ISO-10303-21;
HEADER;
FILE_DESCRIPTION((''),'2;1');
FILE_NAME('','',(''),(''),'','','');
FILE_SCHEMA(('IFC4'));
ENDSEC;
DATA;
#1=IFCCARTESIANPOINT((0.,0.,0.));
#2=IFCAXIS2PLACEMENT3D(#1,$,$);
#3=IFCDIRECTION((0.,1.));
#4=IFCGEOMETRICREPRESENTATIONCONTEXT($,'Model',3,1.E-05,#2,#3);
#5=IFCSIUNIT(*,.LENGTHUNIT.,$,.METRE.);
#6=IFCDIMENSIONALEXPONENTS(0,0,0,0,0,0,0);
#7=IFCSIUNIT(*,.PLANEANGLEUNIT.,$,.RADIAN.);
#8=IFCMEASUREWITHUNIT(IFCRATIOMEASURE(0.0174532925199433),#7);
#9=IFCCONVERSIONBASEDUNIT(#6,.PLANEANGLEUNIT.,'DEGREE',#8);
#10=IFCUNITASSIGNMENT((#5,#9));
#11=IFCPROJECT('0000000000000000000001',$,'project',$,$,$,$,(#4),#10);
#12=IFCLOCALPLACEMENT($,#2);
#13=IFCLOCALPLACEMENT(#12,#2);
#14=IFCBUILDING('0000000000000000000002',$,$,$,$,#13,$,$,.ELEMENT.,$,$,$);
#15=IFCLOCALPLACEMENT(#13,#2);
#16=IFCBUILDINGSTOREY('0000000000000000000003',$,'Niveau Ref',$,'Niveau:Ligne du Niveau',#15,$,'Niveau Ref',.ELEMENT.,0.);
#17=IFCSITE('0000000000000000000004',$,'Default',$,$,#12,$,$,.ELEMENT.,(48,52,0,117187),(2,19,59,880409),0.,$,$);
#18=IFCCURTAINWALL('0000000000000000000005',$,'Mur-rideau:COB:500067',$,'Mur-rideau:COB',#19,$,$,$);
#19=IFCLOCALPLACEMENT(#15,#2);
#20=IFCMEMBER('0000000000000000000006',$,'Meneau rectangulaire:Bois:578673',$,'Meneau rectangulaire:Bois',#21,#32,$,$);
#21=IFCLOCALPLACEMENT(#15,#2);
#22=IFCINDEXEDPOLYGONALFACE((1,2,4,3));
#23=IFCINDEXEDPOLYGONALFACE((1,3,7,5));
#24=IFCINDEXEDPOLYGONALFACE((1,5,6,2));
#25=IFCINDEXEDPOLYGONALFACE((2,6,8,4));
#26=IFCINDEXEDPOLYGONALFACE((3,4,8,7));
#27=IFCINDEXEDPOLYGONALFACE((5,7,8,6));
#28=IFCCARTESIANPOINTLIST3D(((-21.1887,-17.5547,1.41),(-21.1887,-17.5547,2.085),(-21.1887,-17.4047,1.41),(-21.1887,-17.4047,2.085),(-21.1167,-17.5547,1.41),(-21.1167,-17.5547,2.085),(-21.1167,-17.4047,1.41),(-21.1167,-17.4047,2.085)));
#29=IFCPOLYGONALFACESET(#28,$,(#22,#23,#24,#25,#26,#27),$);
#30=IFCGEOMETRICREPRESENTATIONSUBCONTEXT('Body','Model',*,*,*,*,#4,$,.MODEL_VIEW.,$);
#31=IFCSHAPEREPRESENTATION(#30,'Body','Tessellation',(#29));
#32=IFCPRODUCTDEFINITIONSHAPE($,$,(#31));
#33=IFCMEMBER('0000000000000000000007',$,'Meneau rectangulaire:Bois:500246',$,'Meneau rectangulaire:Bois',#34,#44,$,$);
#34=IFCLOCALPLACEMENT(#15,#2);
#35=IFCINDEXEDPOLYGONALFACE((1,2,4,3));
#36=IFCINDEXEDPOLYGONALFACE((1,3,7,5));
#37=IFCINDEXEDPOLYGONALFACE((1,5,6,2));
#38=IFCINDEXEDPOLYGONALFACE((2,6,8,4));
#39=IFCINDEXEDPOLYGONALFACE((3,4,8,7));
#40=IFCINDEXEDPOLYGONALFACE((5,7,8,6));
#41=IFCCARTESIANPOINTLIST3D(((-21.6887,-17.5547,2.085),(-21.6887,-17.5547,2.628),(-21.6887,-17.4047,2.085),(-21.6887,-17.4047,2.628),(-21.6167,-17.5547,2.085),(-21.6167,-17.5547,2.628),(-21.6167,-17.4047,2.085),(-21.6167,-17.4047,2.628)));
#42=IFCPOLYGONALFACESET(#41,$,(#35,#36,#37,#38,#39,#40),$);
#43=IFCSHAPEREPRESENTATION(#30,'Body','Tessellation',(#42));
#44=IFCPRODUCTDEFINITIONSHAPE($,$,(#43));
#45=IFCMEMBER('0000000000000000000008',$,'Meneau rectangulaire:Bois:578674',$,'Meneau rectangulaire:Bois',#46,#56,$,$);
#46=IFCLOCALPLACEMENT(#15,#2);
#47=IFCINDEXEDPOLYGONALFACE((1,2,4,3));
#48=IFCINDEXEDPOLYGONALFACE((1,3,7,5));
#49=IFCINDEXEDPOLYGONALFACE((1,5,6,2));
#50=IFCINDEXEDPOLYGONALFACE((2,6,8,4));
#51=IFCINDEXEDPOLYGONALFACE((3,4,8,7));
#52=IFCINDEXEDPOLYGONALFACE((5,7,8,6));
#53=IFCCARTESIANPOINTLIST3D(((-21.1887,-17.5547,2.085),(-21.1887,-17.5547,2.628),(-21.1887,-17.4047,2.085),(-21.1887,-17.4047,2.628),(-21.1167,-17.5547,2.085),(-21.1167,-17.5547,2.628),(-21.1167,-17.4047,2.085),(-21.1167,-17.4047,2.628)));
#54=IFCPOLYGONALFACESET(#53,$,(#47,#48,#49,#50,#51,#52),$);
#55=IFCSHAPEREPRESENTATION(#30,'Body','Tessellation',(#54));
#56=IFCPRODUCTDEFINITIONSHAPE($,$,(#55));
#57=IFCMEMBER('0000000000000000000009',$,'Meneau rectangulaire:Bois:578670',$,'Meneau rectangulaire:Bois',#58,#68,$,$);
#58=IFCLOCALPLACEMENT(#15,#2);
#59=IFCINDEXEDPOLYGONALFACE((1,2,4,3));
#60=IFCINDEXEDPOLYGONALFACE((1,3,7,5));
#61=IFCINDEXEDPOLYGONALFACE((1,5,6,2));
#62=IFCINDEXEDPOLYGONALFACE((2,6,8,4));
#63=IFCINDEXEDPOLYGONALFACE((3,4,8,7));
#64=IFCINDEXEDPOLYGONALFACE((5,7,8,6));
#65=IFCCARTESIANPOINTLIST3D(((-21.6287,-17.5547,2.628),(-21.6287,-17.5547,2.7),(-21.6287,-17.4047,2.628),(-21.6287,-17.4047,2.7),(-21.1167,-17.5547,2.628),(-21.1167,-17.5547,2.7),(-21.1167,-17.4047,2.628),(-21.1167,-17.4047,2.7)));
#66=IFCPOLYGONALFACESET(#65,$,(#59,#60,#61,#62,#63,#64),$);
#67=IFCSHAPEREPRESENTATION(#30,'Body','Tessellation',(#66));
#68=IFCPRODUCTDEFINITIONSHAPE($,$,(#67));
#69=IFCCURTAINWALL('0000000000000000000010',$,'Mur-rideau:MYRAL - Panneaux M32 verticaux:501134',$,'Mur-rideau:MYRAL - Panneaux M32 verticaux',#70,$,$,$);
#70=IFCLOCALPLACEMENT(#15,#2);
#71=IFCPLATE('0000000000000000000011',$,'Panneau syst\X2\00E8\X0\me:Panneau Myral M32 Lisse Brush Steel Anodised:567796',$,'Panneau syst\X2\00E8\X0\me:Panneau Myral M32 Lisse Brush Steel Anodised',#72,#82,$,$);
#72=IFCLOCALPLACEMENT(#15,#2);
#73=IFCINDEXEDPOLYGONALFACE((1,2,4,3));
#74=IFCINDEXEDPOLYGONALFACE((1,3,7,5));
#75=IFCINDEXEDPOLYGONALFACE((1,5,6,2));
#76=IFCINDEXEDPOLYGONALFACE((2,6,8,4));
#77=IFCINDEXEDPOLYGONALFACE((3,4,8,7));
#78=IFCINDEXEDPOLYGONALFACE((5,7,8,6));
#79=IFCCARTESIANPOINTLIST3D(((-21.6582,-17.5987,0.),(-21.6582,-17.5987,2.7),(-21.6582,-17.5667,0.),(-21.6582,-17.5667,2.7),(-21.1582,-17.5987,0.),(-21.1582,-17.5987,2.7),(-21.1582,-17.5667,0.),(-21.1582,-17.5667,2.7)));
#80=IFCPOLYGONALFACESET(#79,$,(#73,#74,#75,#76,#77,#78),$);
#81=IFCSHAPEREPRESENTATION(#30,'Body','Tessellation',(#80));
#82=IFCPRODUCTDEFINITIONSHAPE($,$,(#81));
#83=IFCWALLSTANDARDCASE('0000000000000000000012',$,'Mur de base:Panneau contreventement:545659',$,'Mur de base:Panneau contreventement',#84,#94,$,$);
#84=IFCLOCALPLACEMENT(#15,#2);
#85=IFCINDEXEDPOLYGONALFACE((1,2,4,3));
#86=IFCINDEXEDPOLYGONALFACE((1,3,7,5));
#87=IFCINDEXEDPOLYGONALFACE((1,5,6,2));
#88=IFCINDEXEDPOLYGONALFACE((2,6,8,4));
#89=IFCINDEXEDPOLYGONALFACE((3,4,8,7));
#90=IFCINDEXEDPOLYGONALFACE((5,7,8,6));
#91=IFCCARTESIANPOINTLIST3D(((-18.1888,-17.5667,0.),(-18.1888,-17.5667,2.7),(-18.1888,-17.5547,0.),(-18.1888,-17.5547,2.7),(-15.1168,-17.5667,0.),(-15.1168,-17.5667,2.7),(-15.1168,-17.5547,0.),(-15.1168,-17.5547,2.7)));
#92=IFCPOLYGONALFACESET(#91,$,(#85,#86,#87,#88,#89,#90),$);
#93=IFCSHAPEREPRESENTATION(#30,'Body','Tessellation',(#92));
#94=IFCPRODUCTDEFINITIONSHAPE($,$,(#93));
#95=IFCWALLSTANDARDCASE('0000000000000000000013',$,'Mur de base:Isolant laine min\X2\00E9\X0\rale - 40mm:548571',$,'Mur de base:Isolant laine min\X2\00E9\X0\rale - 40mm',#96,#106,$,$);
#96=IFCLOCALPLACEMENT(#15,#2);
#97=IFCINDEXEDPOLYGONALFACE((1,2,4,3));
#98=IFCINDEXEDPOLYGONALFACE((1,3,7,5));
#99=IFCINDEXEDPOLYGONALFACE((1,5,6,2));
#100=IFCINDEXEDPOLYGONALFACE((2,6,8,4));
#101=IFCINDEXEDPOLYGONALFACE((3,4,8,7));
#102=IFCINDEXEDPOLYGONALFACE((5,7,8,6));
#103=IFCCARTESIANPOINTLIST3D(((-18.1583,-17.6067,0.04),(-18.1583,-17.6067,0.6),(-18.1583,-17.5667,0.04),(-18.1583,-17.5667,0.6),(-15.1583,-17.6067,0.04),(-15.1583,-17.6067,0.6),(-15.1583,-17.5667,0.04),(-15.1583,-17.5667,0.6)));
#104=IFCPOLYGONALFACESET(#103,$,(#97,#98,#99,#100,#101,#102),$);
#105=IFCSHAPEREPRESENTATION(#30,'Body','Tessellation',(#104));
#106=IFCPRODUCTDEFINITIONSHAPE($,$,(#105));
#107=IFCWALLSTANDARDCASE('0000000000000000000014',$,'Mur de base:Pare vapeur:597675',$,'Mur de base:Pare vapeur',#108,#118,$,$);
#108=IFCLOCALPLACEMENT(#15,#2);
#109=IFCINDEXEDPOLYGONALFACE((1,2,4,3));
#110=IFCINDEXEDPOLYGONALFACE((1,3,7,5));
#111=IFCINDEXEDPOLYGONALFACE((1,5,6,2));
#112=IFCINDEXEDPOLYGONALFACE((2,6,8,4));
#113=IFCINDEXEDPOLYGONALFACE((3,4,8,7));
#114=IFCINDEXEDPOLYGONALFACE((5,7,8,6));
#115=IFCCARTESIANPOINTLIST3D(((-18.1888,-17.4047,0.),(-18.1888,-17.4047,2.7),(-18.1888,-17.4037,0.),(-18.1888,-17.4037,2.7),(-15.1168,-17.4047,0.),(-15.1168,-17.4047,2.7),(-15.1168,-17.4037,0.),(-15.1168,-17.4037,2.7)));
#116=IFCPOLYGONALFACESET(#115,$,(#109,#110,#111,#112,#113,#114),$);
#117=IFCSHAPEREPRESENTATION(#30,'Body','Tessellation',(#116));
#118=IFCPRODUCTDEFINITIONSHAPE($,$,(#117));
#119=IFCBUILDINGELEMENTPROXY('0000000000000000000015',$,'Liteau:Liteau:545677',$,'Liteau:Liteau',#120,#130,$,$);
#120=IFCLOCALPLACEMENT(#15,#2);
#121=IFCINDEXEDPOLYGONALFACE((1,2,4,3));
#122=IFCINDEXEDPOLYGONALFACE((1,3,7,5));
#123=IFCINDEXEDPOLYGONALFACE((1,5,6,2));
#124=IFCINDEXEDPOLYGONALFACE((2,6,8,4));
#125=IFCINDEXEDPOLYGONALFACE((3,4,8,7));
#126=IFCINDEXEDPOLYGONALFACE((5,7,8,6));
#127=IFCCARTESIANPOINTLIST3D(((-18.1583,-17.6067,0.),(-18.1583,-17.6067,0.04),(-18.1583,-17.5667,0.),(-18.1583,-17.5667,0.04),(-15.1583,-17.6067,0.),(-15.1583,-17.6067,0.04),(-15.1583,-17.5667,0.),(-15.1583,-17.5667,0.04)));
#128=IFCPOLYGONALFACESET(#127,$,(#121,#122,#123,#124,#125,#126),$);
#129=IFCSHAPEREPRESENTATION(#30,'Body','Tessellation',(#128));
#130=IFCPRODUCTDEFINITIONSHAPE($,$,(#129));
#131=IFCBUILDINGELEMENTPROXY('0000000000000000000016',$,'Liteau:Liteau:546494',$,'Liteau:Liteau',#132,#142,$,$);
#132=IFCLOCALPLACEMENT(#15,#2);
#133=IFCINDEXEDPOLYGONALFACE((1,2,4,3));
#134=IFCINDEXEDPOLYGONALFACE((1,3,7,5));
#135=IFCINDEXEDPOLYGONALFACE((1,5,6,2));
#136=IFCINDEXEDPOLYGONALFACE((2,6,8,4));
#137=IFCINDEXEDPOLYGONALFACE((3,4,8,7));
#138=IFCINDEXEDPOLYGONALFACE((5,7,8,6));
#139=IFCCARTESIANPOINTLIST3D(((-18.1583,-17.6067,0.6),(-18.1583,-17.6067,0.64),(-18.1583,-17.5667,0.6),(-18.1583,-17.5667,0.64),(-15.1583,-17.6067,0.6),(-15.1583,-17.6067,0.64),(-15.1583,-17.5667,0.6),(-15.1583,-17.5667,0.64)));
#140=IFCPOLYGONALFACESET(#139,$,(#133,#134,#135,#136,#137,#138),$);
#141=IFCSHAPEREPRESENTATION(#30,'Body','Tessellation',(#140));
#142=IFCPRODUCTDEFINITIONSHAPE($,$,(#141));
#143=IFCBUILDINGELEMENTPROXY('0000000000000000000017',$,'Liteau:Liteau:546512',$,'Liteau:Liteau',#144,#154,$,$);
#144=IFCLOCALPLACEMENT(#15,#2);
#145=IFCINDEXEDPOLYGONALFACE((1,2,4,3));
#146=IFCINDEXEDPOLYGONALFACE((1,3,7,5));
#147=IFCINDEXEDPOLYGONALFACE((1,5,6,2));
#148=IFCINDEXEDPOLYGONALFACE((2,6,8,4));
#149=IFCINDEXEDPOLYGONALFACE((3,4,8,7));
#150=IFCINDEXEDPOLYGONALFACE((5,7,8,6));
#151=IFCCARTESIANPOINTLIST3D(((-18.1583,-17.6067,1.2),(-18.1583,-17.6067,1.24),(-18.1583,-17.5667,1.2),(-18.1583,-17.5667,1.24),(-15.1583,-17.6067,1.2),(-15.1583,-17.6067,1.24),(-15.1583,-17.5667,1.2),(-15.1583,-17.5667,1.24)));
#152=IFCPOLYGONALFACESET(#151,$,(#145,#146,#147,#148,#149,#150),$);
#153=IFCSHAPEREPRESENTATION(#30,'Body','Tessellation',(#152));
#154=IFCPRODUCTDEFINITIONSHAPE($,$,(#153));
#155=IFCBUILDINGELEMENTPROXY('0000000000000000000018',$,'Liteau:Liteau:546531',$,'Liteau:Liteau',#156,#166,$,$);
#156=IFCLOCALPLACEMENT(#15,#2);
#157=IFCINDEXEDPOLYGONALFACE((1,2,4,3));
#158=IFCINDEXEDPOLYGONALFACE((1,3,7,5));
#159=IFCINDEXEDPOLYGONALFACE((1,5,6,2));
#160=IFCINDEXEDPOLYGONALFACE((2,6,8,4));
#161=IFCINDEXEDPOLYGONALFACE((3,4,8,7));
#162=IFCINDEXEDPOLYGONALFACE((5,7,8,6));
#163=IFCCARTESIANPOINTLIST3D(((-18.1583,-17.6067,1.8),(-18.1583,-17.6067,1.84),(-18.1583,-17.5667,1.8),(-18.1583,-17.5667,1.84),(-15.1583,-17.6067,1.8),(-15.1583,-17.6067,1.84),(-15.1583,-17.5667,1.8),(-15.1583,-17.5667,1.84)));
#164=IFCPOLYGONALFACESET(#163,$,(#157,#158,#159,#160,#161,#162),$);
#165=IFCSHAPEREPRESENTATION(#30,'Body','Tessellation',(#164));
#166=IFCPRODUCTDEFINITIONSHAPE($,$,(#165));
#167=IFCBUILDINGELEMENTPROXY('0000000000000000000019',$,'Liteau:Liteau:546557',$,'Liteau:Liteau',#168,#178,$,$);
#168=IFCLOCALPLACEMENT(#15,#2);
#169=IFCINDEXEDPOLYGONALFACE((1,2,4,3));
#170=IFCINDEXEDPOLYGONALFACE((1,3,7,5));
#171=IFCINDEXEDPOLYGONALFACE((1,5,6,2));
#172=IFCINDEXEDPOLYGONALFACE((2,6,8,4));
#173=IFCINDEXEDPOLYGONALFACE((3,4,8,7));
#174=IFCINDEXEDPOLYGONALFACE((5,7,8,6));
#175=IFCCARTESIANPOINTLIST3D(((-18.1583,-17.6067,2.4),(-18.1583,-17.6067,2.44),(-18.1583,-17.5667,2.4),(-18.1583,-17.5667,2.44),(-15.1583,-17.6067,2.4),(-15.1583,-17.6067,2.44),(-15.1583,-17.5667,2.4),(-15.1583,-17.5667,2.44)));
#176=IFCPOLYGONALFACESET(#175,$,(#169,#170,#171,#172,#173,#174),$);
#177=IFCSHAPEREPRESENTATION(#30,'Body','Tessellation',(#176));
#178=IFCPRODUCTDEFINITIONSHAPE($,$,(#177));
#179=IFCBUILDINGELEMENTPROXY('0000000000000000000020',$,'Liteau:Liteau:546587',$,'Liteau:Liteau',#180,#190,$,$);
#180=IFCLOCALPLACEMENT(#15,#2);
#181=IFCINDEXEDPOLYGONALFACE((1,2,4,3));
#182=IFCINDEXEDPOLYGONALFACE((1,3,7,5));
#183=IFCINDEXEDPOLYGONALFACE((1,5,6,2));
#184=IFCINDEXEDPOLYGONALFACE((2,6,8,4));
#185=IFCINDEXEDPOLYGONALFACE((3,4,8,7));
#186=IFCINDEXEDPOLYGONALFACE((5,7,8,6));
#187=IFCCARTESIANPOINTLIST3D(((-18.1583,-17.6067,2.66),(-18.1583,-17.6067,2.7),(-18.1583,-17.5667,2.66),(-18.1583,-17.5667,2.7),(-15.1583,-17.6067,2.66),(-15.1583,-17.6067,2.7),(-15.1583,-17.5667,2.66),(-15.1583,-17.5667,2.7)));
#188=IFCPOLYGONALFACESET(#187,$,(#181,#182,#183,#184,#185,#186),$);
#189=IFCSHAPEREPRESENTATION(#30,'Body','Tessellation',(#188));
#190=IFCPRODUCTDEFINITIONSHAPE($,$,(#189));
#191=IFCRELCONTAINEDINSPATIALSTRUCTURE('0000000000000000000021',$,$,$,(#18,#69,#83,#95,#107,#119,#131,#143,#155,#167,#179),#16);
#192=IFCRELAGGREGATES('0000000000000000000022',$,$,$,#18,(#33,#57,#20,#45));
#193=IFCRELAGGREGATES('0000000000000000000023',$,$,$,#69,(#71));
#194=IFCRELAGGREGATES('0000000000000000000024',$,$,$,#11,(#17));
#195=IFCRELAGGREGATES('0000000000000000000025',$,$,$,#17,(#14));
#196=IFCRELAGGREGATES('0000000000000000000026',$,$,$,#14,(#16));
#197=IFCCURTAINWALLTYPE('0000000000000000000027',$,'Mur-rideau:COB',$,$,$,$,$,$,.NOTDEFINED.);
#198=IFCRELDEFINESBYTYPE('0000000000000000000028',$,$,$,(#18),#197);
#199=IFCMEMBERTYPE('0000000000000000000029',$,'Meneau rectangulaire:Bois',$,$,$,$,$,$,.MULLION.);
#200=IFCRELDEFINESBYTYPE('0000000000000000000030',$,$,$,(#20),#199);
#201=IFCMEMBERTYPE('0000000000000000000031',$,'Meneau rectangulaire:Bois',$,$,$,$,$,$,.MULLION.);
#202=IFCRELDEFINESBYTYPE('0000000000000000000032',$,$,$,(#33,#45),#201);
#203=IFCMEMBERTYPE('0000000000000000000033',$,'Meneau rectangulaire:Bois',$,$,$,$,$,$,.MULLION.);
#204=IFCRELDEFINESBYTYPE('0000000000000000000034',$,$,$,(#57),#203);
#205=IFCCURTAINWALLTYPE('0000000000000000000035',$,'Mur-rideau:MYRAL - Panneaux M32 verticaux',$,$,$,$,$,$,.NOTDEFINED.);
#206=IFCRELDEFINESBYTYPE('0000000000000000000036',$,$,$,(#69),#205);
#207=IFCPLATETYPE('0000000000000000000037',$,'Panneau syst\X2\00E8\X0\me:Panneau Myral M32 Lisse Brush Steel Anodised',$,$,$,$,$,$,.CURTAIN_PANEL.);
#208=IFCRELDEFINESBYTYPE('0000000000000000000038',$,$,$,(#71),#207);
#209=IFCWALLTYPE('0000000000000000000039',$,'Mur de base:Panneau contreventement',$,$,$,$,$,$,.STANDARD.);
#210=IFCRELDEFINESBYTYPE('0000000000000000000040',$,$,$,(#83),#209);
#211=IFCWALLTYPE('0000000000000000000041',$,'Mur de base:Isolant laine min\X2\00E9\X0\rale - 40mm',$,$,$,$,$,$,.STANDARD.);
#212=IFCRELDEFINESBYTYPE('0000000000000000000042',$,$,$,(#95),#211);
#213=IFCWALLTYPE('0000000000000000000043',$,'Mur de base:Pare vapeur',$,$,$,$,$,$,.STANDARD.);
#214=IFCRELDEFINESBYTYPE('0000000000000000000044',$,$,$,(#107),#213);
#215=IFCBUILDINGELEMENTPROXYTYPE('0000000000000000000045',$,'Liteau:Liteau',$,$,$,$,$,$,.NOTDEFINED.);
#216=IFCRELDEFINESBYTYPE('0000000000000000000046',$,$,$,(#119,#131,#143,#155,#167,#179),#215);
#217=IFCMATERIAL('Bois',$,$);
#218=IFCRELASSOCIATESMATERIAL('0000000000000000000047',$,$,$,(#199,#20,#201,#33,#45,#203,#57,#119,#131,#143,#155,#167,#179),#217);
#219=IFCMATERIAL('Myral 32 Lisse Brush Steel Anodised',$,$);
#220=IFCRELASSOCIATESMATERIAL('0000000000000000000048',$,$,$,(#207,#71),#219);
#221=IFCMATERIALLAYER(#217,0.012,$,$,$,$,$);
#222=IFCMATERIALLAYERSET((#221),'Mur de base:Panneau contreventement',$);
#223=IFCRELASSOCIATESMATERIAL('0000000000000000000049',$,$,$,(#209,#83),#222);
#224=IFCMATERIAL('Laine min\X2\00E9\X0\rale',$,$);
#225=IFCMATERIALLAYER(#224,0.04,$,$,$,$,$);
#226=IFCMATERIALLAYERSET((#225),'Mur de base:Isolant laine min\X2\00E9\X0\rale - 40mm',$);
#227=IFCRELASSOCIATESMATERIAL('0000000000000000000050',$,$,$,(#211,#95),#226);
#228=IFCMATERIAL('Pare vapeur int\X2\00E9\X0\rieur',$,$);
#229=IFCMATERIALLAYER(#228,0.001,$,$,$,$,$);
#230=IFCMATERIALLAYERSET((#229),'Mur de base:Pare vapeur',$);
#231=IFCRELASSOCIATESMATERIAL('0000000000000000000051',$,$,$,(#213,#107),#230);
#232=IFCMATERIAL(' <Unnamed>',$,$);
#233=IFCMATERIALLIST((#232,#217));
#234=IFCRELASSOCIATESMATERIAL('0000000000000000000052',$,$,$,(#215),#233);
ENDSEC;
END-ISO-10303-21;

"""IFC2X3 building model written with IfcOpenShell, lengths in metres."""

from ifc_helpers import new_model, entity, si_unit, converted_unit, direction, frame, frame_2d, origin, origin_2d_with_axis, place, context, subcontext, project, spatial, rectangle, extrude, source, transform, mapped, material, material_list, layer, layer_set, layer_usage, type_object, type_shapes, element, aggregate, save


model = new_model("IFC2X3")

# Units and contexts
model_context = context("Model", 3, precision=1e-05, world=origin(), true_north=direction((0.0, 1.0)))
body_context = subcontext(model_context, "Body", "Model", "MODEL_VIEW")
ifc_project = project(units=[si_unit("LENGTHUNIT", "METRE"), converted_unit("PLANEANGLEUNIT", "DEGREE", entity("IfcRatioMeasure", 0.0174532925199433), si_unit("PLANEANGLEUNIT", "RADIAN"), dimensions=[0, 0, 0, 0, 0, 0, 0])], contexts=[model_context])

# Site, building, storey
site_placement = place(None, origin())
site = spatial("IfcSite", under=ifc_project, at=site_placement, Name="Default", CompositionType="ELEMENT", RefLatitude=(48, 52, 0, 117187), RefLongitude=(2, 19, 59, 880409), RefElevation=0.0)
building_placement = place(site_placement, origin())
building = spatial("IfcBuilding", under=site, at=building_placement, CompositionType="ELEMENT")
storey_placement = place(building_placement, origin())
storey = spatial("IfcBuildingStorey", under=building, at=storey_placement, Name="Niveau Ref", ObjectType="Niveau:Ligne du Niveau", LongName="Niveau Ref", CompositionType="ELEMENT", Elevation=0.0)

# Curtain wall, members
curtain_wall_type_1 = type_object("IfcCurtainWallType", Name="Mur-rideau:COB", PredefinedType="NOTDEFINED")
ifc_material_1 = material(Name="Bois")
curtain_wall_1_placement = place(storey_placement, origin())
curtain_wall_1 = element("IfcCurtainWall", 1, at=curtain_wall_1_placement, inside=storey, type_object=curtain_wall_type_1, Name="Mur-rideau:COB:500067", ObjectType="Mur-rideau:COB")
member_type_1 = type_object("IfcMemberType", Name="Meneau rectangulaire:Bois", PredefinedType="MULLION", material=ifc_material_1)
shared_shape_1 = source(origin(), body_context, "Body", "SweptSolid", [
    extrude(rectangle(XDim=0.15, YDim=0.072, at=origin_2d_with_axis()), frame((-0.024, 0.0, -0.675), z_axis=(0.0, 0.0, 1.0), x_axis=(0.0, -1.0, 0.0)), (0.0, 0.0, 1.0), 0.675),
])
type_shapes(member_type_1, [shared_shape_1])
member_1_placement = place(storey_placement, frame((-21.1287, -17.4797, 1.41), z_axis=(0.0, 0.0, -1.0), x_axis=(1.0, 0.0, 0.0)))
member_1 = element("IfcMember", 2, at=member_1_placement, type_object=member_type_1, material=ifc_material_1, Name="Meneau rectangulaire:Bois:578673", ObjectType="Meneau rectangulaire:Bois", context=body_context, shape_type="MappedRepresentation", body=[
    mapped(shared_shape_1, transform((0.0, 0.0, 0.0), scale=1.0)),
])
member_type_2 = type_object("IfcMemberType", Name="Meneau rectangulaire:Bois", PredefinedType="MULLION", material=ifc_material_1)
shared_shape_2 = source(origin(), body_context, "Body", "SweptSolid", [
    extrude(rectangle(XDim=0.15, YDim=0.072, at=origin_2d_with_axis()), frame((-0.024, 0.0, -0.543), z_axis=(0.0, 0.0, 1.0), x_axis=(0.0, -1.0, 0.0)), (0.0, 0.0, 1.0), 0.543),
])
type_shapes(member_type_2, [shared_shape_2])
member_2_placement = place(storey_placement, frame((-21.6287, -17.4797, 2.085), z_axis=(0.0, 0.0, -1.0), x_axis=(1.0, 0.0, 0.0)))
member_2 = element("IfcMember", 3, at=member_2_placement, type_object=member_type_2, material=ifc_material_1, Name="Meneau rectangulaire:Bois:500246", ObjectType="Meneau rectangulaire:Bois", context=body_context, shape_type="MappedRepresentation", body=[
    mapped(shared_shape_2, transform((0.0, 0.0, 0.0), scale=1.0)),
])
member_3_placement = place(storey_placement, frame((-21.1287, -17.4797, 2.085), z_axis=(0.0, 0.0, -1.0), x_axis=(1.0, 0.0, 0.0)))
member_3 = element("IfcMember", 4, at=member_3_placement, type_object=member_type_2, material=ifc_material_1, Name="Meneau rectangulaire:Bois:578674", ObjectType="Meneau rectangulaire:Bois", context=body_context, shape_type="MappedRepresentation", body=[
    mapped(shared_shape_2, transform((0.0, 0.0, 0.0), scale=1.0)),
])
member_type_3 = type_object("IfcMemberType", Name="Meneau rectangulaire:Bois", PredefinedType="MULLION", material=ifc_material_1)
shared_shape_3 = source(origin(), body_context, "Body", "SweptSolid", [
    extrude(rectangle(XDim=0.15, YDim=0.072, at=origin_2d_with_axis()), frame((-0.036, 0.0, -0.512), z_axis=(0.0, 0.0, 1.0), x_axis=(0.0, -1.0, 0.0)), (0.0, 0.0, 1.0), 0.512),
])
type_shapes(member_type_3, [shared_shape_3])
member_4_placement = place(storey_placement, frame((-21.1167, -17.4797, 2.7), z_axis=(1.0, 0.0, 0.0), x_axis=(0.0, 0.0, 1.0)))
member_4 = element("IfcMember", 5, at=member_4_placement, type_object=member_type_3, material=ifc_material_1, Name="Meneau rectangulaire:Bois:578670", ObjectType="Meneau rectangulaire:Bois", context=body_context, shape_type="MappedRepresentation", body=[
    mapped(shared_shape_3, transform((0.0, 0.0, 0.0), scale=1.0)),
])
aggregate(curtain_wall_1, [member_2, member_4, member_1, member_3])

# Curtain wall, plate
curtain_wall_type_2 = type_object("IfcCurtainWallType", Name="Mur-rideau:MYRAL - Panneaux M32 verticaux", PredefinedType="NOTDEFINED")
curtain_wall_2_placement = place(storey_placement, origin())
curtain_wall_2 = element("IfcCurtainWall", 6, at=curtain_wall_2_placement, inside=storey, type_object=curtain_wall_type_2, Name="Mur-rideau:MYRAL - Panneaux M32 verticaux:501134", ObjectType="Mur-rideau:MYRAL - Panneaux M32 verticaux")
ifc_material_2 = material(Name="Myral 32 Lisse Brush Steel Anodised")
plate_type = type_object("IfcPlateType", Name="Panneau système:Panneau Myral M32 Lisse Brush Steel Anodised", PredefinedType="CURTAIN_PANEL", material=ifc_material_2)
shared_shape_4 = source(origin(), body_context, "Body", "SweptSolid", [
    extrude(rectangle(XDim=0.032, YDim=0.5, at=origin_2d_with_axis()), frame((0.0, -0.016, 0.0), z_axis=(0.0, 0.0, 1.0), x_axis=(0.0, 1.0, 0.0)), (0.0, 0.0, 1.0), 2.7),
])
type_shapes(plate_type, [shared_shape_4])
plate_placement = place(curtain_wall_2_placement, frame((-21.4082, -17.5667, 0.0)))
plate = element("IfcPlate", 7, at=plate_placement, type_object=plate_type, material=ifc_material_2, Name="Panneau système:Panneau Myral M32 Lisse Brush Steel Anodised:567796", ObjectType="Panneau système:Panneau Myral M32 Lisse Brush Steel Anodised", context=body_context, shape_type="MappedRepresentation", body=[
    mapped(shared_shape_4, transform((0.0, 0.0, 0.0), scale=1.0)),
])
aggregate(curtain_wall_2, [plate])

# Walls
ifc_layer_1 = layer(ifc_material_1, 0.012)
ifc_layer_set_1 = layer_set([ifc_layer_1], Name="Mur de base:Panneau contreventement")
ifc_layer_usage_1 = layer_usage(ifc_layer_set_1, "AXIS2", "NEGATIVE", 0.006)
wall_type_1 = type_object("IfcWallType", Name="Mur de base:Panneau contreventement", PredefinedType="STANDARD", material=ifc_layer_set_1)
wall_1_placement = place(storey_placement, frame((-18.1888, -17.5607, 0.0)))
element("IfcWallStandardCase", 8, at=wall_1_placement, inside=storey, type_object=wall_type_1, material=ifc_layer_usage_1, Name="Mur de base:Panneau contreventement:545659", ObjectType="Mur de base:Panneau contreventement", context=body_context, shape_type="SweptSolid", body=[
    extrude(rectangle(XDim=3.072, YDim=0.012, at=frame_2d((1.536, 0.0), x_axis=(-1.0, 0.0))), origin(), (0.0, 0.0, 1.0), 2.7),
])
ifc_material_3 = material(Name="Laine minérale")
ifc_layer_2 = layer(ifc_material_3, 0.04)
ifc_layer_set_2 = layer_set([ifc_layer_2], Name="Mur de base:Isolant laine minérale - 40mm")
ifc_layer_usage_2 = layer_usage(ifc_layer_set_2, "AXIS2", "NEGATIVE", 0.02)
wall_type_2 = type_object("IfcWallType", Name="Mur de base:Isolant laine minérale - 40mm", PredefinedType="STANDARD", material=ifc_layer_set_2)
wall_2_placement = place(storey_placement, frame((-18.1583, -17.5867, 0.04)))
element("IfcWallStandardCase", 9, at=wall_2_placement, inside=storey, type_object=wall_type_2, material=ifc_layer_usage_2, Name="Mur de base:Isolant laine minérale - 40mm:548571", ObjectType="Mur de base:Isolant laine minérale - 40mm", context=body_context, shape_type="SweptSolid", body=[
    extrude(rectangle(XDim=3.0, YDim=0.04, at=frame_2d((1.5, 0.0), x_axis=(-1.0, 0.0))), origin(), (0.0, 0.0, 1.0), 0.56),
])
ifc_material_4 = material(Name="Pare vapeur intérieur")
ifc_layer_3 = layer(ifc_material_4, 0.001)
ifc_layer_set_3 = layer_set([ifc_layer_3], Name="Mur de base:Pare vapeur")
ifc_layer_usage_3 = layer_usage(ifc_layer_set_3, "AXIS2", "NEGATIVE", 0.0005)
wall_type_3 = type_object("IfcWallType", Name="Mur de base:Pare vapeur", PredefinedType="STANDARD", material=ifc_layer_set_3)
wall_3_placement = place(storey_placement, frame((-18.1888, -17.4042, 0.0)))
element("IfcWallStandardCase", 10, at=wall_3_placement, inside=storey, type_object=wall_type_3, material=ifc_layer_usage_3, Name="Mur de base:Pare vapeur:597675", ObjectType="Mur de base:Pare vapeur", context=body_context, shape_type="SweptSolid", body=[
    extrude(rectangle(XDim=3.072, YDim=0.001, at=frame_2d((1.536, 0.0), x_axis=(-1.0, 0.0))), origin(), (0.0, 0.0, 1.0), 2.7),
])

# Building element proxies
ifc_material_5 = material(Name=" <Unnamed>")
ifc_material_list = material_list([ifc_material_5, ifc_material_1])
building_element_proxy_type = type_object("IfcBuildingElementProxyType", Name="Liteau:Liteau", PredefinedType="NOTDEFINED", material=ifc_material_list)
shared_shape_5 = source(origin(), body_context, "Body", "SweptSolid", [
    extrude(rectangle(XDim=3.0, YDim=0.04, at=origin_2d_with_axis()), frame((1.5, -0.02, 0.0), z_axis=(0.0, 0.0, 1.0), x_axis=(-1.0, 0.0, 0.0)), (0.0, 0.0, 1.0), 0.04),
])
type_shapes(building_element_proxy_type, [shared_shape_5])
for number, where, name in (
    (11, (-18.1583, -17.5667, 0.0), "Liteau:Liteau:545677"),
    (12, (-18.1583, -17.5667, 0.6), "Liteau:Liteau:546494"),
    (13, (-18.1583, -17.5667, 1.2), "Liteau:Liteau:546512"),
    (14, (-18.1583, -17.5667, 1.8), "Liteau:Liteau:546531"),
    (15, (-18.1583, -17.5667, 2.4), "Liteau:Liteau:546557"),
    (16, (-18.1583, -17.5667, 2.66), "Liteau:Liteau:546587"),
):
    element("IfcBuildingElementProxy", number, at=place(storey_placement, frame(where)), inside=storey, type_object=building_element_proxy_type, material=ifc_material_1, Name=name, ObjectType="Liteau:Liteau", context=body_context, shape_type="MappedRepresentation", body=[
        mapped(shared_shape_5, transform((0.0, 0.0, 0.0), scale=1.0)),
    ])

save(model, "model.ifc")
